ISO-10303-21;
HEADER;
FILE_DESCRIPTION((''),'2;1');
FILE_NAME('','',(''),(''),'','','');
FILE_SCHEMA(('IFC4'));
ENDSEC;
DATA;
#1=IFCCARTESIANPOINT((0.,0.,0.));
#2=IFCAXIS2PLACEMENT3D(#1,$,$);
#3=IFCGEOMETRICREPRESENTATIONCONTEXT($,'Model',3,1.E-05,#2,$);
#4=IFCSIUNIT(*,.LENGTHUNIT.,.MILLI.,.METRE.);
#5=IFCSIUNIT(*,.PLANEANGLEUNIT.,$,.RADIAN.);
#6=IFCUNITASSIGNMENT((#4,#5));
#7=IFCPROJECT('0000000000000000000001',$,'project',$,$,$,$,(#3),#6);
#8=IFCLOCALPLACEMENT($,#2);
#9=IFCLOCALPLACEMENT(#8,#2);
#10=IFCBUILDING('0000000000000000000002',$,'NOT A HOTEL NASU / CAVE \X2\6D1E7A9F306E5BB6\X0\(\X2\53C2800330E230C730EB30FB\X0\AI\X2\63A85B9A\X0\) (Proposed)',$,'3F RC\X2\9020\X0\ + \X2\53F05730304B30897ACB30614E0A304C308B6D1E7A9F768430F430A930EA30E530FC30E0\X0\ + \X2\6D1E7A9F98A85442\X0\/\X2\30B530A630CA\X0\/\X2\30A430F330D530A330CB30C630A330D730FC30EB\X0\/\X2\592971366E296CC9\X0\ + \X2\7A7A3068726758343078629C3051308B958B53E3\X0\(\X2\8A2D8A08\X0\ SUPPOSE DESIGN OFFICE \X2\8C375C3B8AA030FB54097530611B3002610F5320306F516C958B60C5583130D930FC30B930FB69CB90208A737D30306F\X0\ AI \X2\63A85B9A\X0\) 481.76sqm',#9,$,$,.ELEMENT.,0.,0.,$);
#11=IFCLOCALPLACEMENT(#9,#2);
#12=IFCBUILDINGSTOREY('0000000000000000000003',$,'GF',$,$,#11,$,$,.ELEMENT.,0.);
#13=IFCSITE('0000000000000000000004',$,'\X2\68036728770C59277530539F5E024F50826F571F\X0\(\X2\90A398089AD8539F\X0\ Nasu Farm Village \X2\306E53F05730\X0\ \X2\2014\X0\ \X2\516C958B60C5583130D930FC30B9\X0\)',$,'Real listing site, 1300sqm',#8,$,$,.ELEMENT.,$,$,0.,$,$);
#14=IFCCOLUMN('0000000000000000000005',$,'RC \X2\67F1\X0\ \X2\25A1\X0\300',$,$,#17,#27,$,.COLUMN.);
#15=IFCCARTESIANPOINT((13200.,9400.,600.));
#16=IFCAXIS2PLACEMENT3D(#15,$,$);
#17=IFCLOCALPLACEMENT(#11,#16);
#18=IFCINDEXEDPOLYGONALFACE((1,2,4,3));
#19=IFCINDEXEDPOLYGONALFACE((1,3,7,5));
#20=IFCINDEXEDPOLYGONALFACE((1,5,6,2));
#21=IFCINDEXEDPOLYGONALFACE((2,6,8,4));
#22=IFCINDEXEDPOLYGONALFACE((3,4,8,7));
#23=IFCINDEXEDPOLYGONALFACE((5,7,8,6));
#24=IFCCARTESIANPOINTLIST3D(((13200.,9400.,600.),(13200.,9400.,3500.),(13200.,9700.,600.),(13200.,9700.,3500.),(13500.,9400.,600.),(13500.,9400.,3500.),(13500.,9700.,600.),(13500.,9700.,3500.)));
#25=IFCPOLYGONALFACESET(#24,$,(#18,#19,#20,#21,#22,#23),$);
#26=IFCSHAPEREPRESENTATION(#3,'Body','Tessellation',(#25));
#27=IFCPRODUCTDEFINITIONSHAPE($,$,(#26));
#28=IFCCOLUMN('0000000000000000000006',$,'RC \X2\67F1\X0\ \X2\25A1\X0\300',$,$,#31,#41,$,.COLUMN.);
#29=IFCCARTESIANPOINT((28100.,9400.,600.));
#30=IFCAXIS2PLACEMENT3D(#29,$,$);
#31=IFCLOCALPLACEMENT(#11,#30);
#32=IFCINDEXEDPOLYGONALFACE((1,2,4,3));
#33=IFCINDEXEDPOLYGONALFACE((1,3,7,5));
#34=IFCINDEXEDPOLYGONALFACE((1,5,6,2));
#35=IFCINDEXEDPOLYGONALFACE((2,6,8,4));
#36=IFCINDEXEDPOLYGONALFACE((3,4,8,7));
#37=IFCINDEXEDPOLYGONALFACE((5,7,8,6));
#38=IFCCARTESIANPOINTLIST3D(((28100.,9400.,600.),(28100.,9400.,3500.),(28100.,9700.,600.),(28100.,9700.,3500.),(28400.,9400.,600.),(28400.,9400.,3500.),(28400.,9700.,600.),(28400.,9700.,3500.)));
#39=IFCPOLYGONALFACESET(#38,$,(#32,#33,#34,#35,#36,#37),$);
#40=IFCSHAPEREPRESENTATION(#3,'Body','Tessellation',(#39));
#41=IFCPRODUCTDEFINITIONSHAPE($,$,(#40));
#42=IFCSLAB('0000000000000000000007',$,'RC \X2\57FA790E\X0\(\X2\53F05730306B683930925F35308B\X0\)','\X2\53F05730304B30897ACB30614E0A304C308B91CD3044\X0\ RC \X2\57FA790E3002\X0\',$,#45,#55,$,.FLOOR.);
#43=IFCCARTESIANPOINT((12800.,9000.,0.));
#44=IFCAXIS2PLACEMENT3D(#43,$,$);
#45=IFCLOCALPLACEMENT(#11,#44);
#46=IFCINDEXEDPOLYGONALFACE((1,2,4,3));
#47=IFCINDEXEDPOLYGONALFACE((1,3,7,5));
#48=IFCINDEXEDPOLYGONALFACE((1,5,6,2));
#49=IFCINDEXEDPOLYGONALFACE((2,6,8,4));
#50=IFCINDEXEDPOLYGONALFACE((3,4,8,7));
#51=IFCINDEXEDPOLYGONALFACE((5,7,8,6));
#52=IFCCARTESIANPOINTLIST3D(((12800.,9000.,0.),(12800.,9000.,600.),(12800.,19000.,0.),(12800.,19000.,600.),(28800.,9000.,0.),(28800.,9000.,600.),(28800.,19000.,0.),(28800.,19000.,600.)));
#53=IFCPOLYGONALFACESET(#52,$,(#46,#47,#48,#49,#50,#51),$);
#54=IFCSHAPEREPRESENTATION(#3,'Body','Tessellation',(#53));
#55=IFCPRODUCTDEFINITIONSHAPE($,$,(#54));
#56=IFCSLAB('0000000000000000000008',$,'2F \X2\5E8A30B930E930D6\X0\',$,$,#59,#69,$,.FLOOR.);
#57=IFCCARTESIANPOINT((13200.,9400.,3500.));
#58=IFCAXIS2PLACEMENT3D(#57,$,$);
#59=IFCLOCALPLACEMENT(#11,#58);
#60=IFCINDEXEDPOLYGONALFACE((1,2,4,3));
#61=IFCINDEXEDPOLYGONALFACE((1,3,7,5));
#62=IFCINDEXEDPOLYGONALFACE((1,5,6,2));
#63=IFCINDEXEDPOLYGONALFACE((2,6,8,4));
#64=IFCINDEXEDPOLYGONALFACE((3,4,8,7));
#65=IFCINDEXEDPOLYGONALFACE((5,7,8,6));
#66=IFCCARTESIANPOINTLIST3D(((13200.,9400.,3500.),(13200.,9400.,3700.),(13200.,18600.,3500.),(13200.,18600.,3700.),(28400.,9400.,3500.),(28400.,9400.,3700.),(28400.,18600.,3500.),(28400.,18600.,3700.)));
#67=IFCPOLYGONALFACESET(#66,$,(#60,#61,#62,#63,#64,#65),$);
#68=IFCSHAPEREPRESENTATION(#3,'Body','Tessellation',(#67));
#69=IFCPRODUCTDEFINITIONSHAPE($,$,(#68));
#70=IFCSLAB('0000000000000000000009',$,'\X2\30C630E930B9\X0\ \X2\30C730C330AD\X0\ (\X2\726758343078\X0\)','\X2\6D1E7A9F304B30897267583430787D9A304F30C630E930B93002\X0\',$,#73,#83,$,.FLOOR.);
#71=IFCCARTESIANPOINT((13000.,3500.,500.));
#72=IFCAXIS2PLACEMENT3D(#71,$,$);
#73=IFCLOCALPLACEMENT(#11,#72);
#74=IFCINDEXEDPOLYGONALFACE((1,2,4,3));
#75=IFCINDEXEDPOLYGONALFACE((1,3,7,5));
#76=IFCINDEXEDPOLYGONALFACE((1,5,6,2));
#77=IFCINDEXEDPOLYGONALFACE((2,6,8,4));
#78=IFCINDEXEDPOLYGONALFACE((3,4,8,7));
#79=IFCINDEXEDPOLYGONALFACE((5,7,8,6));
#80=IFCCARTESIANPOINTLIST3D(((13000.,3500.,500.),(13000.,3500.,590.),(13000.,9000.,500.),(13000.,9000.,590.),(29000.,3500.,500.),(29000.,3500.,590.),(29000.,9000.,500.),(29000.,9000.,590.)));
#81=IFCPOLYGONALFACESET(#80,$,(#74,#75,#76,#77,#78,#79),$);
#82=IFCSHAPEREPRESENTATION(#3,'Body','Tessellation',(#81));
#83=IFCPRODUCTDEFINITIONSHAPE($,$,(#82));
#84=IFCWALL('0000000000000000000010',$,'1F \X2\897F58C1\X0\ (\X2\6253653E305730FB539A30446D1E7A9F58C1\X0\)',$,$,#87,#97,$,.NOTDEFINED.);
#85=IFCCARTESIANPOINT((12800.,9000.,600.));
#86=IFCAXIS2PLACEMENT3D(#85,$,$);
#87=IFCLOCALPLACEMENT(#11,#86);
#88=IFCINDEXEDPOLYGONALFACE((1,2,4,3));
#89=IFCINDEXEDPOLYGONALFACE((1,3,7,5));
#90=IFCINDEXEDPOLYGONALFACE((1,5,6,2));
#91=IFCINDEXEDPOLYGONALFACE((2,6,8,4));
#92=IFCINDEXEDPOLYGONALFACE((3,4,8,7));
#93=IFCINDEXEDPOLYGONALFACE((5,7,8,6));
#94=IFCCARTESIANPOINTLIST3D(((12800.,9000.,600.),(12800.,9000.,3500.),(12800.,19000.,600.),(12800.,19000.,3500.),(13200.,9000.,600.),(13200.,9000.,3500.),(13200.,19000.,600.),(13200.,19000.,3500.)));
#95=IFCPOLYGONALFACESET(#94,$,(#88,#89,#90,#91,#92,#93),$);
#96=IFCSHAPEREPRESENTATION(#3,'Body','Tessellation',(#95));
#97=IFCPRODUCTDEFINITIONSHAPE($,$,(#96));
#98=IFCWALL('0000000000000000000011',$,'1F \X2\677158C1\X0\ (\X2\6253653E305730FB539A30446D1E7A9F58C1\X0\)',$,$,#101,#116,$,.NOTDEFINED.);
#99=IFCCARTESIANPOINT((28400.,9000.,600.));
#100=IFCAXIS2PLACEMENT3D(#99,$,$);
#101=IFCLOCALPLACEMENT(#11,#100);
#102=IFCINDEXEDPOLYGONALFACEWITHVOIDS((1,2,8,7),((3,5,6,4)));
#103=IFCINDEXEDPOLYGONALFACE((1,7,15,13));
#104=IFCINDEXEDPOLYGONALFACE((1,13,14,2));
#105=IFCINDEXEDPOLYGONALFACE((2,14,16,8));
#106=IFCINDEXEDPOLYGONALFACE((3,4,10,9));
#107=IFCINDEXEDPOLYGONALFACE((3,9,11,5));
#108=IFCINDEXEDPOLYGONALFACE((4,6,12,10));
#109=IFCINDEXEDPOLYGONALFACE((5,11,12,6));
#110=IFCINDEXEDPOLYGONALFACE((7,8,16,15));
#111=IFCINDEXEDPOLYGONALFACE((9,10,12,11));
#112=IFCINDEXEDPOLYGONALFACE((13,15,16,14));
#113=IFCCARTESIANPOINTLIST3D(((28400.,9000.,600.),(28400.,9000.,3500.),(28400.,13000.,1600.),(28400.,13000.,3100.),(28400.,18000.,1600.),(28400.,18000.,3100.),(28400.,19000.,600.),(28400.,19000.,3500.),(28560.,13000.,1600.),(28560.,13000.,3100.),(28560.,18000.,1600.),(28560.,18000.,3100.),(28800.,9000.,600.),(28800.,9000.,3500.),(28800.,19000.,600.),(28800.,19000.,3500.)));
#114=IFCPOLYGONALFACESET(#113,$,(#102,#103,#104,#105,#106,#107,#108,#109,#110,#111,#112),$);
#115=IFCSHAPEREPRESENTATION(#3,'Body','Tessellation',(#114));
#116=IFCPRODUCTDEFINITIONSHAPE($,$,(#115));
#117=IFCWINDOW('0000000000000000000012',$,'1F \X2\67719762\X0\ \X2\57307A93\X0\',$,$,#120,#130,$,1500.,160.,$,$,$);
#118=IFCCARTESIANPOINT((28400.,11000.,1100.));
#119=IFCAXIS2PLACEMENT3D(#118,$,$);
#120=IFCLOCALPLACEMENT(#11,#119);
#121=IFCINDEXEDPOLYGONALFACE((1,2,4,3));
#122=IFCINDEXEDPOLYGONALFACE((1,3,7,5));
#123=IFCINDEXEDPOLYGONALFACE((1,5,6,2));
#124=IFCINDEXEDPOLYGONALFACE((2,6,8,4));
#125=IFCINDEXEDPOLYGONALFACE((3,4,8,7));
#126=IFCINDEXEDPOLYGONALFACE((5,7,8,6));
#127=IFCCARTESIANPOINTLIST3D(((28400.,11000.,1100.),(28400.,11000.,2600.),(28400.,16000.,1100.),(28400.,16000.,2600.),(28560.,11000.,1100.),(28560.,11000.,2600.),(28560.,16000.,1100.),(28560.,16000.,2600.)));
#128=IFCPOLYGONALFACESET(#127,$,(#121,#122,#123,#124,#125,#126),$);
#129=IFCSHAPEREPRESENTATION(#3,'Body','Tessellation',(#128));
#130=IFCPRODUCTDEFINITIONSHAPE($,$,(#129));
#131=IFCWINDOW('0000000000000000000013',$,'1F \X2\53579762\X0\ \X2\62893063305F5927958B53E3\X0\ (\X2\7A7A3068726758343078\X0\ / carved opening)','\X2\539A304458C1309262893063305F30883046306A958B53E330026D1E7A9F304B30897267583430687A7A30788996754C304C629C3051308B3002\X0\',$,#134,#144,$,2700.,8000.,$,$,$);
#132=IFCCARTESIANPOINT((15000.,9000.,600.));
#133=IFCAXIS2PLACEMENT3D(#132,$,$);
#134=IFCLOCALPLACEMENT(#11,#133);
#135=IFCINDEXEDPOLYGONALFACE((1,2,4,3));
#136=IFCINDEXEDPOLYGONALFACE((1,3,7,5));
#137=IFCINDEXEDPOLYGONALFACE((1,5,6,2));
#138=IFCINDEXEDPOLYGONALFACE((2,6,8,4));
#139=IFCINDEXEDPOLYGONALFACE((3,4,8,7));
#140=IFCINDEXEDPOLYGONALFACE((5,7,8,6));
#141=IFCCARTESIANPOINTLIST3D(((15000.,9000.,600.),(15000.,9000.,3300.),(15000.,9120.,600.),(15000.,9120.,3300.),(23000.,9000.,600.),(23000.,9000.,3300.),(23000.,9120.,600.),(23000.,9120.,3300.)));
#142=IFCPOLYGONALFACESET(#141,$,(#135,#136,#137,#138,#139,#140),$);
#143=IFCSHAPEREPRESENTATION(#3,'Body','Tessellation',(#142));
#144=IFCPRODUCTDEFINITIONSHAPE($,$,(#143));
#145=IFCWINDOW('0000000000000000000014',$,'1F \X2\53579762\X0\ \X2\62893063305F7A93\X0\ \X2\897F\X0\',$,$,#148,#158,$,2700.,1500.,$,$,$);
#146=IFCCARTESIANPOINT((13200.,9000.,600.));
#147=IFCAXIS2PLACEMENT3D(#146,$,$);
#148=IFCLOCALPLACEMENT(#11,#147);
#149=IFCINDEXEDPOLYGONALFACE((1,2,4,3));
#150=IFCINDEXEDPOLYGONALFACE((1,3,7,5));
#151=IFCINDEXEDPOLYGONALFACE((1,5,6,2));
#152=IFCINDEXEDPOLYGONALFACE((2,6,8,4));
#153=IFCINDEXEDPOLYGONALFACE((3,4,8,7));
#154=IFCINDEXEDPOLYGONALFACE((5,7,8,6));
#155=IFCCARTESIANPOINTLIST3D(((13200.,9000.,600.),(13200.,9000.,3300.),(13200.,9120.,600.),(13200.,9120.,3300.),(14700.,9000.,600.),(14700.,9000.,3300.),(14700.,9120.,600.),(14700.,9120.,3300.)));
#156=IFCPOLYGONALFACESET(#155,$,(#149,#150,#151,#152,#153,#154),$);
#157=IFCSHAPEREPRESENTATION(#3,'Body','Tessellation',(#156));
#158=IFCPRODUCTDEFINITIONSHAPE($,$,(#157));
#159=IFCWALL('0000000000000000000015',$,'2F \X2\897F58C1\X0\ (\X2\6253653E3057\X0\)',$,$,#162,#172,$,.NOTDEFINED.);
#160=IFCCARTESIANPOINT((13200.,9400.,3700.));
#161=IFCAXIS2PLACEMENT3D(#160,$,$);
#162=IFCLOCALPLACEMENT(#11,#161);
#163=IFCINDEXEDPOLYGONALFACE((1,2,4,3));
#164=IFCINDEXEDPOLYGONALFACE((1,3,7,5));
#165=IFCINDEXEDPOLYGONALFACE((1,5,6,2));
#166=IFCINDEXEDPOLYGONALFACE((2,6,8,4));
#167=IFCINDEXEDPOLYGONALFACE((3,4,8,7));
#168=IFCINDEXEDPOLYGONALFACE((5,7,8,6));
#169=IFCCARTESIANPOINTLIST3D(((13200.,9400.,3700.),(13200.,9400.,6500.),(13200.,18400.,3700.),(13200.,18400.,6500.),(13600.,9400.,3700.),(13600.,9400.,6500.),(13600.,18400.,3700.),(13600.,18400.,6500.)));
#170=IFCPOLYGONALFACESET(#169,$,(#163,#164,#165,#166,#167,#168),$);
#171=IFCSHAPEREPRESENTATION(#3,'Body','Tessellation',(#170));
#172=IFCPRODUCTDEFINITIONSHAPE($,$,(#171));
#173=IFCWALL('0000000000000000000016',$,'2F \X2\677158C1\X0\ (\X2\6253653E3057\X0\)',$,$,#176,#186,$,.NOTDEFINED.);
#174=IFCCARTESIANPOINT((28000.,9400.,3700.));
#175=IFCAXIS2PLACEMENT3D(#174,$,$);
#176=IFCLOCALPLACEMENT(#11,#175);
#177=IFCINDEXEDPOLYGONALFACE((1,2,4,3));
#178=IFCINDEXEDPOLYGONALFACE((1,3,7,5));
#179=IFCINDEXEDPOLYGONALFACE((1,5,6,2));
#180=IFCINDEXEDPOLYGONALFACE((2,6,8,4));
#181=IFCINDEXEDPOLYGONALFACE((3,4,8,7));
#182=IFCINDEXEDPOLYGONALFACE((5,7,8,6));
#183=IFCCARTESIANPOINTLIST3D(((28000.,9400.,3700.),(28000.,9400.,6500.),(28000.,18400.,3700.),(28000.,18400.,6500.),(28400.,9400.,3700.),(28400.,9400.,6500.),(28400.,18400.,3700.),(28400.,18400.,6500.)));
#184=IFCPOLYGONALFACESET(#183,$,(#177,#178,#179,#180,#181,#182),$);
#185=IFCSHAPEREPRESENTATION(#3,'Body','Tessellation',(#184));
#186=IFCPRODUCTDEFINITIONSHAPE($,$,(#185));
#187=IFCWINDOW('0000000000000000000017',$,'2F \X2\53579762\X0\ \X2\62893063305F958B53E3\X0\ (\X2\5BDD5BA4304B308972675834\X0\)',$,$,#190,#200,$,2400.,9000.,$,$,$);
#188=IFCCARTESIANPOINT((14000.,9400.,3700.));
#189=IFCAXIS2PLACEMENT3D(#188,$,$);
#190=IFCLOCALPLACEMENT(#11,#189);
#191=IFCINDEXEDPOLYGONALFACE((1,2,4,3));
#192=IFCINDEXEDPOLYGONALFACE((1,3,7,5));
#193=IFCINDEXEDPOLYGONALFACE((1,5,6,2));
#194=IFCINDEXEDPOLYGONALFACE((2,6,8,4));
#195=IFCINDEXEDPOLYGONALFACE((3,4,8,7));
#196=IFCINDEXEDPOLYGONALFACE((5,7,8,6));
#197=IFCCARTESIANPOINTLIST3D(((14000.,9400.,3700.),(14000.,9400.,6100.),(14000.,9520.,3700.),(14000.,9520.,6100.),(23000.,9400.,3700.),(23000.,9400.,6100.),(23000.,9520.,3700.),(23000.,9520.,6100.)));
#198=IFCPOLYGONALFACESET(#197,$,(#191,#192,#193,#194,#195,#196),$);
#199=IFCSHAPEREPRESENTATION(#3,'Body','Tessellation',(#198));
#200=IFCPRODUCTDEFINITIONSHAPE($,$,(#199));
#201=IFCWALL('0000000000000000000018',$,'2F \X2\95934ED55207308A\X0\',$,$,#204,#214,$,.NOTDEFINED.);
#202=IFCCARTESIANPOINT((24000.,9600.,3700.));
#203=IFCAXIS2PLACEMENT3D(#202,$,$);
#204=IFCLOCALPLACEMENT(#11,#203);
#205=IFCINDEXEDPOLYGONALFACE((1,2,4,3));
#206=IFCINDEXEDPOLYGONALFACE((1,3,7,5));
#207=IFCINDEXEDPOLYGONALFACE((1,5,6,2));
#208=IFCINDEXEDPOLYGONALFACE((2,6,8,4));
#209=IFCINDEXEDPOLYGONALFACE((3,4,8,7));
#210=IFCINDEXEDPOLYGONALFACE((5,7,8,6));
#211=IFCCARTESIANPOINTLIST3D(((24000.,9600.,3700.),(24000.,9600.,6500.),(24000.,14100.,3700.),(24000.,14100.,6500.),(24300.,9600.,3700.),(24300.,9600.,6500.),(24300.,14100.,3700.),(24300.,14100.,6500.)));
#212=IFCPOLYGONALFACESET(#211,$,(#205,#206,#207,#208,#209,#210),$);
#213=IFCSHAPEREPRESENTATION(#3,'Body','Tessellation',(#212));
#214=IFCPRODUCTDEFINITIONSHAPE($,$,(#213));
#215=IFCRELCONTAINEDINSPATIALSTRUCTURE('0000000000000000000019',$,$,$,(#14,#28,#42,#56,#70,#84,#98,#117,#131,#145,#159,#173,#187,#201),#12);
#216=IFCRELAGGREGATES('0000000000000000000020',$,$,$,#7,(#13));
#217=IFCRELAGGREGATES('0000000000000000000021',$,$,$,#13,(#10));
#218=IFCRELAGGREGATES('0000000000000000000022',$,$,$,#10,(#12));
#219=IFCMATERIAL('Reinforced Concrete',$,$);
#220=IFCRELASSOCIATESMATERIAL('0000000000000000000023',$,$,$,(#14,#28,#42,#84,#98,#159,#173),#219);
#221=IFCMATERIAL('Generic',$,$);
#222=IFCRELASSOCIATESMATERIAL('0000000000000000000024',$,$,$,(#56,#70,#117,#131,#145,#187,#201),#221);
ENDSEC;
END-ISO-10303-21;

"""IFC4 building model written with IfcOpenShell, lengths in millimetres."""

from ifc_helpers import new_model, si_unit, frame, frame_2d, origin, place, context, project, spatial, rectangle, extrude, material, element, fill, save


model = new_model("IFC4")

# Units and contexts
model_context = context("Model", 3, precision=1e-05, world=origin())
ifc_project = project(units=[si_unit("LENGTHUNIT", "METRE", prefix="MILLI"), si_unit("PLANEANGLEUNIT", "RADIAN")], contexts=[model_context])

# Site, building, storey
site_placement = place(None, origin())
site = spatial("IfcSite", under=ifc_project, at=site_placement, Name="栃木県大田原市佐良土(那須高原 Nasu Farm Village の台地 — 公開情報ベース)", ObjectType="Real listing site, 1300sqm", CompositionType="ELEMENT", RefElevation=0.0)
building_placement = place(site_placement, origin())
building = spatial("IfcBuilding", under=site, at=building_placement, Name="NOT A HOTEL NASU / CAVE 洞窟の家(参考モデル・AI推定) (Proposed)", ObjectType="3F RC造 + 台地から立ち上がる洞窟的ヴォリューム + 洞窟風呂/サウナ/インフィニティプール/天然温泉 + 空と牧場へ抜ける開口(設計 SUPPOSE DESIGN OFFICE 谷尻誠・吉田愛。意匠は公開情報ベース・構造詳細は AI 推定) 481.76sqm", CompositionType="ELEMENT", ElevationOfRefHeight=0.0, ElevationOfTerrain=0.0)
storey_placement = place(building_placement, origin())
storey = spatial("IfcBuildingStorey", under=building, at=storey_placement, Name="GF", CompositionType="ELEMENT", Elevation=0.0)

# Columns
ifc_material_1 = material(Name="Reinforced Concrete")
column_1_placement = place(storey_placement, frame((13200.0, 9400.0, 600.0)))
element("IfcColumn", 1, at=column_1_placement, inside=storey, material=ifc_material_1, Name="RC 柱 □300", PredefinedType="COLUMN", context=model_context, shape_type="SweptSolid", body=[
    extrude(rectangle(XDim=300.0, YDim=300.0, at=frame_2d((150.0, 150.0))), frame((13200.0, 9400.0, 600.0)), (0.0, 0.0, 1.0), 2900.0),
])
column_2_placement = place(storey_placement, frame((28100.0, 9400.0, 600.0)))
element("IfcColumn", 2, at=column_2_placement, inside=storey, material=ifc_material_1, Name="RC 柱 □300", PredefinedType="COLUMN", context=model_context, shape_type="SweptSolid", body=[
    extrude(rectangle(XDim=300.0, YDim=300.0, at=frame_2d((150.0, 150.0))), frame((28100.0, 9400.0, 600.0)), (0.0, 0.0, 1.0), 2900.0),
])

# Slabs
slab_1_placement = place(storey_placement, frame((12800.0, 9000.0, 0.0)))
element("IfcSlab", 3, at=slab_1_placement, inside=storey, material=ifc_material_1, Name="RC 基礎(台地に根を張る)", Description="台地から立ち上がる重い RC 基礎。", PredefinedType="FLOOR", context=model_context, shape_type="SweptSolid", body=[
    extrude(rectangle(XDim=16000.0, YDim=10000.0, at=frame_2d((8000.0, 5000.0))), frame((12800.0, 9000.0, 0.0)), (0.0, 0.0, 1.0), 600.0),
])
ifc_material_2 = material(Name="Generic")
slab_2_placement = place(storey_placement, frame((13200.0, 9400.0, 3500.0)))
element("IfcSlab", 4, at=slab_2_placement, inside=storey, material=ifc_material_2, Name="2F 床スラブ", PredefinedType="FLOOR", context=model_context, shape_type="SweptSolid", body=[
    extrude(rectangle(XDim=15200.0, YDim=9200.0, at=frame_2d((7600.0, 4600.0))), frame((13200.0, 9400.0, 3500.0)), (0.0, 0.0, 1.0), 200.0),
])
slab_3_placement = place(storey_placement, frame((13000.0, 3500.0, 500.0)))
element("IfcSlab", 5, at=slab_3_placement, inside=storey, material=ifc_material_2, Name="テラス デッキ (牧場へ)", Description="洞窟から牧場へ続くテラス。", PredefinedType="FLOOR", context=model_context, shape_type="SweptSolid", body=[
    extrude(rectangle(XDim=16000.0, YDim=5500.0, at=frame_2d((8000.0, 2750.0))), frame((13000.0, 3500.0, 500.0)), (0.0, 0.0, 1.0), 90.0),
])

# Wall
wall_1_placement = place(storey_placement, frame((12800.0, 9000.0, 600.0)))
element("IfcWall", 6, at=wall_1_placement, inside=storey, material=ifc_material_1, Name="1F 西壁 (打放し・厚い洞窟壁)", PredefinedType="NOTDEFINED", context=model_context, shape_type="SweptSolid", body=[
    extrude(rectangle(XDim=400.0, YDim=10000.0, at=frame_2d((200.0, 5000.0))), frame((12800.0, 9000.0, 600.0)), (0.0, 0.0, 1.0), 2900.0),
])

# Wall, opening, window
wall_2_placement = place(storey_placement, frame((28400.0, 9000.0, 600.0)))
wall_2 = element("IfcWall", 7, at=wall_2_placement, inside=storey, material=ifc_material_1, Name="1F 東壁 (打放し・厚い洞窟壁)", PredefinedType="NOTDEFINED", context=model_context, shape_type="SweptSolid", body=[
    extrude(rectangle(XDim=400.0, YDim=10000.0, at=frame_2d((200.0, 5000.0))), frame((28400.0, 9000.0, 600.0)), (0.0, 0.0, 1.0), 2900.0),
])
opening_placement = place(storey_placement, frame((28400.0, 11000.0, 1100.0)))
opening = element("IfcOpeningElement", 8, at=opening_placement, cuts=wall_2, PredefinedType="NOTDEFINED", context=model_context, shape_type="SweptSolid", body=[
    extrude(rectangle(XDim=160.0, YDim=5000.0, at=frame_2d((80.0, 2500.0))), frame((28400.0, 11000.0, 1100.0)), (0.0, 0.0, 1.0), 1500.0),
])
window_1_placement = place(storey_placement, frame((28400.0, 11000.0, 1100.0)))
window_1 = element("IfcWindow", 9, at=window_1_placement, inside=storey, material=ifc_material_2, Name="1F 東面 地窓", OverallHeight=1500.0, OverallWidth=160.0, context=model_context, shape_type="SweptSolid", body=[
    extrude(rectangle(XDim=160.0, YDim=5000.0, at=frame_2d((80.0, 2500.0))), frame((28400.0, 11000.0, 1100.0)), (0.0, 0.0, 1.0), 1500.0),
])
fill(opening, window_1)

# Windows
window_2_placement = place(storey_placement, frame((15000.0, 9000.0, 600.0)))
element("IfcWindow", 10, at=window_2_placement, inside=storey, material=ifc_material_2, Name="1F 南面 抉った大開口 (空と牧場へ / carved opening)", Description="厚い壁を抉ったような開口。洞窟から牧場と空へ視界が抜ける。", OverallHeight=2700.0, OverallWidth=8000.0, context=model_context, shape_type="SweptSolid", body=[
    extrude(rectangle(XDim=8000.0, YDim=120.0, at=frame_2d((4000.0, 60.0))), frame((15000.0, 9000.0, 600.0)), (0.0, 0.0, 1.0), 2700.0),
])
window_3_placement = place(storey_placement, frame((13200.0, 9000.0, 600.0)))
element("IfcWindow", 11, at=window_3_placement, inside=storey, material=ifc_material_2, Name="1F 南面 抉った窓 西", OverallHeight=2700.0, OverallWidth=1500.0, context=model_context, shape_type="SweptSolid", body=[
    extrude(rectangle(XDim=1500.0, YDim=120.0, at=frame_2d((750.0, 60.0))), frame((13200.0, 9000.0, 600.0)), (0.0, 0.0, 1.0), 2700.0),
])

# Walls
wall_3_placement = place(storey_placement, frame((13200.0, 9400.0, 3700.0)))
element("IfcWall", 12, at=wall_3_placement, inside=storey, material=ifc_material_1, Name="2F 西壁 (打放し)", PredefinedType="NOTDEFINED", context=model_context, shape_type="SweptSolid", body=[
    extrude(rectangle(XDim=400.0, YDim=9000.0, at=frame_2d((200.0, 4500.0))), frame((13200.0, 9400.0, 3700.0)), (0.0, 0.0, 1.0), 2800.0),
])
wall_4_placement = place(storey_placement, frame((28000.0, 9400.0, 3700.0)))
element("IfcWall", 13, at=wall_4_placement, inside=storey, material=ifc_material_1, Name="2F 東壁 (打放し)", PredefinedType="NOTDEFINED", context=model_context, shape_type="SweptSolid", body=[
    extrude(rectangle(XDim=400.0, YDim=9000.0, at=frame_2d((200.0, 4500.0))), frame((28000.0, 9400.0, 3700.0)), (0.0, 0.0, 1.0), 2800.0),
])

# Window
window_4_placement = place(storey_placement, frame((14000.0, 9400.0, 3700.0)))
element("IfcWindow", 14, at=window_4_placement, inside=storey, material=ifc_material_2, Name="2F 南面 抉った開口 (寝室から牧場)", OverallHeight=2400.0, OverallWidth=9000.0, context=model_context, shape_type="SweptSolid", body=[
    extrude(rectangle(XDim=9000.0, YDim=120.0, at=frame_2d((4500.0, 60.0))), frame((14000.0, 9400.0, 3700.0)), (0.0, 0.0, 1.0), 2400.0),
])

# Wall
wall_5_placement = place(storey_placement, frame((24000.0, 9600.0, 3700.0)))
element("IfcWall", 15, at=wall_5_placement, inside=storey, material=ifc_material_2, Name="2F 間仕切り", PredefinedType="NOTDEFINED", context=model_context, shape_type="SweptSolid", body=[
    extrude(rectangle(XDim=300.0, YDim=4500.0, at=frame_2d((150.0, 2250.0))), frame((24000.0, 9600.0, 3700.0)), (0.0, 0.0, 1.0), 2800.0),
])

save(model, "model.ifc")
